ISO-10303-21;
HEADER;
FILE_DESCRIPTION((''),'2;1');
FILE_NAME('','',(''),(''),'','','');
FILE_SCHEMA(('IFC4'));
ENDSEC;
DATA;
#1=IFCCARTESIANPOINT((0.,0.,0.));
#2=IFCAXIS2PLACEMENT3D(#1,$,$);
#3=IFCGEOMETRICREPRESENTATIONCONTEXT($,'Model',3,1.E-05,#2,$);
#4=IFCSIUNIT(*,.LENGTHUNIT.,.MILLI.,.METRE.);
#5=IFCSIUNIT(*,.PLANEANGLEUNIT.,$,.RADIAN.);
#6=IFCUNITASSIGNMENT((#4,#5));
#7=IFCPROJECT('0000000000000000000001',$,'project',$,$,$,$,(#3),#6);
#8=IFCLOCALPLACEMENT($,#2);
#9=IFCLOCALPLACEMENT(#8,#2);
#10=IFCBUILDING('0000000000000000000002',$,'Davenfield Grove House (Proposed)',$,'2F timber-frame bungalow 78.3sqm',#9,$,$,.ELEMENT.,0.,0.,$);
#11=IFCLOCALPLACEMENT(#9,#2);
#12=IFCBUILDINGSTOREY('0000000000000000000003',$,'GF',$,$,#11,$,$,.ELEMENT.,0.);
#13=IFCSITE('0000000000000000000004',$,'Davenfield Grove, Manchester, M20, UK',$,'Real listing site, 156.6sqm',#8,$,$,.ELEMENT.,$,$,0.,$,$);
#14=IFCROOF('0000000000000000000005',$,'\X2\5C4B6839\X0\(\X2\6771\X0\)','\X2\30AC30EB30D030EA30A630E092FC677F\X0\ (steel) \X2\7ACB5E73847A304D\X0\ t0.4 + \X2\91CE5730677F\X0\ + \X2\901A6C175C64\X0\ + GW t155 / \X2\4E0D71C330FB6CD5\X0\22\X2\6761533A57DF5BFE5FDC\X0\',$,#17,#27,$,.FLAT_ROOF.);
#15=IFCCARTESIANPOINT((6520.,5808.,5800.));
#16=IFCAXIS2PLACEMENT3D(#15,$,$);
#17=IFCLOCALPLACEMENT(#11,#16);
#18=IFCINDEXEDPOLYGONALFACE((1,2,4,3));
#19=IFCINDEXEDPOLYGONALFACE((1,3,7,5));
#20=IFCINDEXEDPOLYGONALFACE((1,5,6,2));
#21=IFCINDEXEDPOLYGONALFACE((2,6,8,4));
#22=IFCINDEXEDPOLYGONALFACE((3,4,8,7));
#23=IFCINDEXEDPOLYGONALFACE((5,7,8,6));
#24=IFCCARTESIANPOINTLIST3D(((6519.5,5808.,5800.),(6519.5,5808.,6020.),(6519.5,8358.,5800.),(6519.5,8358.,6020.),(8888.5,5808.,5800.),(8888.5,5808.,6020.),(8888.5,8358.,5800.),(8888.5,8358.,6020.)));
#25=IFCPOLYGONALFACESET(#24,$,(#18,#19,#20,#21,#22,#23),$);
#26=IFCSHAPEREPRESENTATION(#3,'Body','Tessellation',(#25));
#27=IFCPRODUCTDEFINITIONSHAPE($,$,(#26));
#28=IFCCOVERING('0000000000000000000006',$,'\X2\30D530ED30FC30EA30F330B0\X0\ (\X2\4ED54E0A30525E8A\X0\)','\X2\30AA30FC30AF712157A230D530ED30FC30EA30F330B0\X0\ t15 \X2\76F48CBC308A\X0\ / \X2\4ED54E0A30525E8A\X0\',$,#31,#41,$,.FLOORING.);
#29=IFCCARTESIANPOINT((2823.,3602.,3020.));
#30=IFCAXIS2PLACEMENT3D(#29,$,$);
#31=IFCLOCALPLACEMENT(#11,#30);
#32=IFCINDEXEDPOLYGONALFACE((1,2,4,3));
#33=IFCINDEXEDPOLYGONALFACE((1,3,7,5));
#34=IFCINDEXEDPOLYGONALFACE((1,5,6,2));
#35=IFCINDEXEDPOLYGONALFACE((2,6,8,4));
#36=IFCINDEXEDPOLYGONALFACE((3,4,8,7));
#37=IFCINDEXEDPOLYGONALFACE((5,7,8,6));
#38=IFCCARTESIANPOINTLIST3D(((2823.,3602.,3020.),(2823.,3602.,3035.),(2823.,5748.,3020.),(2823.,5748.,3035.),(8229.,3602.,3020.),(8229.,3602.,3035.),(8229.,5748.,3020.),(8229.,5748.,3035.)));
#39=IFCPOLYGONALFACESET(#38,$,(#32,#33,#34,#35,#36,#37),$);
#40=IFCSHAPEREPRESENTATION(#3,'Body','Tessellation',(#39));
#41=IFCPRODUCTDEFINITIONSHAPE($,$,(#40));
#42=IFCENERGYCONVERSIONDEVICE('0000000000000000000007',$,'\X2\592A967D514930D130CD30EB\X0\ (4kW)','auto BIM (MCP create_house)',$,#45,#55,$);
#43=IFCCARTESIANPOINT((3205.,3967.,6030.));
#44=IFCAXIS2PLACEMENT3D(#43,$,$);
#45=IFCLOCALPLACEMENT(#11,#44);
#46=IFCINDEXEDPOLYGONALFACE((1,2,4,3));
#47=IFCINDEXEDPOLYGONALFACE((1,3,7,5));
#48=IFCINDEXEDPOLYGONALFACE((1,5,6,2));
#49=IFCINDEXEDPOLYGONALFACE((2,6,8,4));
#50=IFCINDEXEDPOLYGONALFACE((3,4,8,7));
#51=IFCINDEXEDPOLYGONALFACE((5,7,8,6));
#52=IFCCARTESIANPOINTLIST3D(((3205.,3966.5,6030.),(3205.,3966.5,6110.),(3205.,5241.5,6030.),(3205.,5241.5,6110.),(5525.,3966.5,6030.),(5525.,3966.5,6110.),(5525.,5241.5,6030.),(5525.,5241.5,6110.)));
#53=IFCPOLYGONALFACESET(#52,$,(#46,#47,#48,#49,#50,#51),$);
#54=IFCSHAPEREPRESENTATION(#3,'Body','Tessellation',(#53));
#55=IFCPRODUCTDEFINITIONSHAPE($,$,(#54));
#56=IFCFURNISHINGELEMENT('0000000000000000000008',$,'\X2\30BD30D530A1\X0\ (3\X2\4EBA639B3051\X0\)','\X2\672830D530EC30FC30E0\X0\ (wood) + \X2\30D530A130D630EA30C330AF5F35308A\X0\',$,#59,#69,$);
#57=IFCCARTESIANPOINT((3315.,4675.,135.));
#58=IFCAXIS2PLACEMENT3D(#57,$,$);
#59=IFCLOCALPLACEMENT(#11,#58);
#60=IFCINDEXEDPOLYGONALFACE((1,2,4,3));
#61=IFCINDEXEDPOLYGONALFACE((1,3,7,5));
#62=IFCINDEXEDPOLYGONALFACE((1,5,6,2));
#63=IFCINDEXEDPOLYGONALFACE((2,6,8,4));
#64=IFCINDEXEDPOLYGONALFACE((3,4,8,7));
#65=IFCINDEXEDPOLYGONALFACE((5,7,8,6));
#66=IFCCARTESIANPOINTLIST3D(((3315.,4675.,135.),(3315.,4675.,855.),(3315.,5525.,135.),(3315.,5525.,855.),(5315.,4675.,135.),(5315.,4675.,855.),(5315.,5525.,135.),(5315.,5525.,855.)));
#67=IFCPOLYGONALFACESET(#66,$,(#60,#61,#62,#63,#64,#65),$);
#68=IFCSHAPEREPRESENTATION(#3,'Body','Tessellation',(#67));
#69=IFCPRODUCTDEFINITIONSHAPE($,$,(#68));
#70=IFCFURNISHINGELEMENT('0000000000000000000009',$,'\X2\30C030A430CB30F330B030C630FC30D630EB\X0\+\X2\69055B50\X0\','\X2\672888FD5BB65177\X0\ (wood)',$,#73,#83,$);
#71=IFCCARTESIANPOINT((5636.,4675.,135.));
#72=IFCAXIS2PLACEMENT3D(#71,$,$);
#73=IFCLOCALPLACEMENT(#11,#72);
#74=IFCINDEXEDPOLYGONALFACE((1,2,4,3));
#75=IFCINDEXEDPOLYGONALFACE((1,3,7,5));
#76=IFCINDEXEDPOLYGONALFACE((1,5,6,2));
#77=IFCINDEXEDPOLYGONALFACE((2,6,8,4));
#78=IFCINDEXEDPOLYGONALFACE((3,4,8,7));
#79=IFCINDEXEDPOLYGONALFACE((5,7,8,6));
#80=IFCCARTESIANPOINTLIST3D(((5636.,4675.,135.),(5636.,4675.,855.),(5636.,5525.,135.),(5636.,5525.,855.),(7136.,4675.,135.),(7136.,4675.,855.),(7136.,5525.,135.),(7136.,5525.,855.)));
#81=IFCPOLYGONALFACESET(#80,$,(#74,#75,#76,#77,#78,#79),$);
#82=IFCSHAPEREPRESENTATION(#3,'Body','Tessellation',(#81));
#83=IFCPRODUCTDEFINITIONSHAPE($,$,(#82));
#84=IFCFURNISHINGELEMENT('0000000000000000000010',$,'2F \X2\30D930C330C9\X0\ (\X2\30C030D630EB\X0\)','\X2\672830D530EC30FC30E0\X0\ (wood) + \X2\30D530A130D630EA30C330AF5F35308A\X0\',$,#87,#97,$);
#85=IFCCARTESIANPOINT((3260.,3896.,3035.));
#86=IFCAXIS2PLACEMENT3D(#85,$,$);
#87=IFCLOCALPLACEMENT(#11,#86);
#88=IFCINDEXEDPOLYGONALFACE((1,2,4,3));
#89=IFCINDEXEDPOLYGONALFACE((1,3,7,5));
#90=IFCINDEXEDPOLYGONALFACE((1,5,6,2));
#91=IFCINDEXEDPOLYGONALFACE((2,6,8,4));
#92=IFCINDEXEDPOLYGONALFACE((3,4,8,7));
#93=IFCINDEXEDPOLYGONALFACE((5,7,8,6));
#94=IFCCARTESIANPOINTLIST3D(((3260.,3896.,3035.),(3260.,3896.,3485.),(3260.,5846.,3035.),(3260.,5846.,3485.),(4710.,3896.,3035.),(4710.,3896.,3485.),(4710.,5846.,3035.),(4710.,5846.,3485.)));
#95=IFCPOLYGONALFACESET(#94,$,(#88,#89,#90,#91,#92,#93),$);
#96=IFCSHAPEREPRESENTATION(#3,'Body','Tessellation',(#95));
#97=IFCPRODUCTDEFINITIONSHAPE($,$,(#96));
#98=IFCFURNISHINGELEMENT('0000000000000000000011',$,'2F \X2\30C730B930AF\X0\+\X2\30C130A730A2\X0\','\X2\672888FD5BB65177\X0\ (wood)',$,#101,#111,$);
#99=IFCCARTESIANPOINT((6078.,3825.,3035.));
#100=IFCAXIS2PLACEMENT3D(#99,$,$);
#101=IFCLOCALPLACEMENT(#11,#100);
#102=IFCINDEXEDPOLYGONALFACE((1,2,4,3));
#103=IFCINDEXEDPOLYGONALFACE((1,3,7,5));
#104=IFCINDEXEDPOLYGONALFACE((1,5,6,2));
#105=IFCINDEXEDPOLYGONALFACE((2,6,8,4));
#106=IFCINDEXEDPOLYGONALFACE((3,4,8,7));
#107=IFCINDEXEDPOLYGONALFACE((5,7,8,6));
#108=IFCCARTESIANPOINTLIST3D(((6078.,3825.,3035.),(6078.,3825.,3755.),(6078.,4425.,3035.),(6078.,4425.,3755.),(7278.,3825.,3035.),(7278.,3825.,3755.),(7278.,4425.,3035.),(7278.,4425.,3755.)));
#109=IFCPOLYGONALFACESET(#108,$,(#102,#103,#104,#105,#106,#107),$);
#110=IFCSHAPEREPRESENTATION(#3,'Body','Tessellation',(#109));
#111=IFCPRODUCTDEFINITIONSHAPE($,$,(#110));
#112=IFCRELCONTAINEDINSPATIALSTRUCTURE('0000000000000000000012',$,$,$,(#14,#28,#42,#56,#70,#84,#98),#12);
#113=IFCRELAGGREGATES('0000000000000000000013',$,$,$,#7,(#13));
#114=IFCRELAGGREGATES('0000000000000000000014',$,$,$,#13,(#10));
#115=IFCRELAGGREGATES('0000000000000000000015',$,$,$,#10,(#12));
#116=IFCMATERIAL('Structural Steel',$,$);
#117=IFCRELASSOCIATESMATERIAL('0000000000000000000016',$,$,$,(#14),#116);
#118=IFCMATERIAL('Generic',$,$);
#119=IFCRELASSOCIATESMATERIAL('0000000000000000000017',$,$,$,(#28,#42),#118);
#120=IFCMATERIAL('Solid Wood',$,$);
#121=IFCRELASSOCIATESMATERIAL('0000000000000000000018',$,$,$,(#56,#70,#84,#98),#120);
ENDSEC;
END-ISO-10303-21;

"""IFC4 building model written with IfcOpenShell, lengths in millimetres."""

from ifc_helpers import new_model, si_unit, frame, frame_2d, origin, place, context, project, spatial, rectangle, extrude, material, element, save


model = new_model("IFC4")

# Units and contexts
model_context = context("Model", 3, precision=1e-05, world=origin())
ifc_project = project(units=[si_unit("LENGTHUNIT", "METRE", prefix="MILLI"), si_unit("PLANEANGLEUNIT", "RADIAN")], contexts=[model_context])

# Site, building, storey
site_placement = place(None, origin())
site = spatial("IfcSite", under=ifc_project, at=site_placement, Name="Davenfield Grove, Manchester, M20, UK", ObjectType="Real listing site, 156.6sqm", CompositionType="ELEMENT", RefElevation=0.0)
building_placement = place(site_placement, origin())
building = spatial("IfcBuilding", under=site, at=building_placement, Name="Davenfield Grove House (Proposed)", ObjectType="2F timber-frame bungalow 78.3sqm", CompositionType="ELEMENT", ElevationOfRefHeight=0.0, ElevationOfTerrain=0.0)
storey_placement = place(building_placement, origin())
storey = spatial("IfcBuildingStorey", under=building, at=storey_placement, Name="GF", CompositionType="ELEMENT", Elevation=0.0)

# Shared definitions
ifc_material_1 = material(Name="Solid Wood")

# Roof
ifc_material_2 = material(Name="Structural Steel")
roof_1_placement = place(storey_placement, frame((6520.0, 5808.0, 5800.0)))
element("IfcRoof", 1, at=roof_1_placement, inside=storey, material=ifc_material_2, Name="屋根(東)", Description="ガルバリウム鋼板 (steel) 立平葺き t0.4 + 野地板 + 通気層 + GW t155 / 不燃・法22条区域対応", PredefinedType="FLAT_ROOF", context=model_context, shape_type="SweptSolid", body=[
    extrude(rectangle(XDim=2369.0, YDim=2550.0, at=frame_2d((1184.0, 1275.0))), frame((6520.0, 5808.0, 5800.0)), (0.0, 0.0, 1.0), 220.0),
])

# Covering
ifc_material_3 = material(Name="Generic")
covering_placement = place(storey_placement, frame((2823.0, 3602.0, 3020.0)))
element("IfcCovering", 2, at=covering_placement, inside=storey, material=ifc_material_3, Name="フローリング (仕上げ床)", Description="オーク無垢フローリング t15 直貼り / 仕上げ床", PredefinedType="FLOORING", context=model_context, shape_type="SweptSolid", body=[
    extrude(rectangle(XDim=5406.0, YDim=2146.0, at=frame_2d((2703.0, 1073.0))), frame((2823.0, 3602.0, 3020.0)), (0.0, 0.0, 1.0), 15.0),
])

# Energy conversion device
energy_conversion_device_placement = place(storey_placement, frame((3205.0, 3967.0, 6030.0)))
element("IfcEnergyConversionDevice", 3, at=energy_conversion_device_placement, inside=storey, material=ifc_material_3, Name="太陽光パネル (4kW)", Description="auto BIM (MCP create_house)", context=model_context, shape_type="SweptSolid", body=[
    extrude(rectangle(XDim=2320.0, YDim=1275.0, at=frame_2d((1160.0, 637.0))), frame((3205.0, 3967.0, 6030.0)), (0.0, 0.0, 1.0), 80.0),
])

# Furnishing elements
furnishing_1_placement = place(storey_placement, frame((3315.0, 4675.0, 135.0)))
element("IfcFurnishingElement", 4, at=furnishing_1_placement, inside=storey, material=ifc_material_1, Name="ソファ (3人掛け)", Description="木フレーム (wood) + ファブリック張り", context=model_context, shape_type="SweptSolid", body=[
    extrude(rectangle(XDim=2000.0, YDim=850.0, at=frame_2d((1000.0, 425.0))), frame((3315.0, 4675.0, 135.0)), (0.0, 0.0, 1.0), 720.0),
])
furnishing_2_placement = place(storey_placement, frame((5636.0, 4675.0, 135.0)))
element("IfcFurnishingElement", 5, at=furnishing_2_placement, inside=storey, material=ifc_material_1, Name="ダイニングテーブル+椅子", Description="木製家具 (wood)", context=model_context, shape_type="SweptSolid", body=[
    extrude(rectangle(XDim=1500.0, YDim=850.0, at=frame_2d((750.0, 425.0))), frame((5636.0, 4675.0, 135.0)), (0.0, 0.0, 1.0), 720.0),
])
furnishing_3_placement = place(storey_placement, frame((3260.0, 3896.0, 3035.0)))
element("IfcFurnishingElement", 6, at=furnishing_3_placement, inside=storey, material=ifc_material_1, Name="2F ベッド (ダブル)", Description="木フレーム (wood) + ファブリック張り", context=model_context, shape_type="SweptSolid", body=[
    extrude(rectangle(XDim=1450.0, YDim=1950.0, at=frame_2d((725.0, 975.0))), frame((3260.0, 3896.0, 3035.0)), (0.0, 0.0, 1.0), 450.0),
])
furnishing_4_placement = place(storey_placement, frame((6078.0, 3825.0, 3035.0)))
element("IfcFurnishingElement", 7, at=furnishing_4_placement, inside=storey, material=ifc_material_1, Name="2F デスク+チェア", Description="木製家具 (wood)", context=model_context, shape_type="SweptSolid", body=[
    extrude(rectangle(XDim=1200.0, YDim=600.0, at=frame_2d((600.0, 300.0))), frame((6078.0, 3825.0, 3035.0)), (0.0, 0.0, 1.0), 720.0),
])

save(model, "model.ifc")
